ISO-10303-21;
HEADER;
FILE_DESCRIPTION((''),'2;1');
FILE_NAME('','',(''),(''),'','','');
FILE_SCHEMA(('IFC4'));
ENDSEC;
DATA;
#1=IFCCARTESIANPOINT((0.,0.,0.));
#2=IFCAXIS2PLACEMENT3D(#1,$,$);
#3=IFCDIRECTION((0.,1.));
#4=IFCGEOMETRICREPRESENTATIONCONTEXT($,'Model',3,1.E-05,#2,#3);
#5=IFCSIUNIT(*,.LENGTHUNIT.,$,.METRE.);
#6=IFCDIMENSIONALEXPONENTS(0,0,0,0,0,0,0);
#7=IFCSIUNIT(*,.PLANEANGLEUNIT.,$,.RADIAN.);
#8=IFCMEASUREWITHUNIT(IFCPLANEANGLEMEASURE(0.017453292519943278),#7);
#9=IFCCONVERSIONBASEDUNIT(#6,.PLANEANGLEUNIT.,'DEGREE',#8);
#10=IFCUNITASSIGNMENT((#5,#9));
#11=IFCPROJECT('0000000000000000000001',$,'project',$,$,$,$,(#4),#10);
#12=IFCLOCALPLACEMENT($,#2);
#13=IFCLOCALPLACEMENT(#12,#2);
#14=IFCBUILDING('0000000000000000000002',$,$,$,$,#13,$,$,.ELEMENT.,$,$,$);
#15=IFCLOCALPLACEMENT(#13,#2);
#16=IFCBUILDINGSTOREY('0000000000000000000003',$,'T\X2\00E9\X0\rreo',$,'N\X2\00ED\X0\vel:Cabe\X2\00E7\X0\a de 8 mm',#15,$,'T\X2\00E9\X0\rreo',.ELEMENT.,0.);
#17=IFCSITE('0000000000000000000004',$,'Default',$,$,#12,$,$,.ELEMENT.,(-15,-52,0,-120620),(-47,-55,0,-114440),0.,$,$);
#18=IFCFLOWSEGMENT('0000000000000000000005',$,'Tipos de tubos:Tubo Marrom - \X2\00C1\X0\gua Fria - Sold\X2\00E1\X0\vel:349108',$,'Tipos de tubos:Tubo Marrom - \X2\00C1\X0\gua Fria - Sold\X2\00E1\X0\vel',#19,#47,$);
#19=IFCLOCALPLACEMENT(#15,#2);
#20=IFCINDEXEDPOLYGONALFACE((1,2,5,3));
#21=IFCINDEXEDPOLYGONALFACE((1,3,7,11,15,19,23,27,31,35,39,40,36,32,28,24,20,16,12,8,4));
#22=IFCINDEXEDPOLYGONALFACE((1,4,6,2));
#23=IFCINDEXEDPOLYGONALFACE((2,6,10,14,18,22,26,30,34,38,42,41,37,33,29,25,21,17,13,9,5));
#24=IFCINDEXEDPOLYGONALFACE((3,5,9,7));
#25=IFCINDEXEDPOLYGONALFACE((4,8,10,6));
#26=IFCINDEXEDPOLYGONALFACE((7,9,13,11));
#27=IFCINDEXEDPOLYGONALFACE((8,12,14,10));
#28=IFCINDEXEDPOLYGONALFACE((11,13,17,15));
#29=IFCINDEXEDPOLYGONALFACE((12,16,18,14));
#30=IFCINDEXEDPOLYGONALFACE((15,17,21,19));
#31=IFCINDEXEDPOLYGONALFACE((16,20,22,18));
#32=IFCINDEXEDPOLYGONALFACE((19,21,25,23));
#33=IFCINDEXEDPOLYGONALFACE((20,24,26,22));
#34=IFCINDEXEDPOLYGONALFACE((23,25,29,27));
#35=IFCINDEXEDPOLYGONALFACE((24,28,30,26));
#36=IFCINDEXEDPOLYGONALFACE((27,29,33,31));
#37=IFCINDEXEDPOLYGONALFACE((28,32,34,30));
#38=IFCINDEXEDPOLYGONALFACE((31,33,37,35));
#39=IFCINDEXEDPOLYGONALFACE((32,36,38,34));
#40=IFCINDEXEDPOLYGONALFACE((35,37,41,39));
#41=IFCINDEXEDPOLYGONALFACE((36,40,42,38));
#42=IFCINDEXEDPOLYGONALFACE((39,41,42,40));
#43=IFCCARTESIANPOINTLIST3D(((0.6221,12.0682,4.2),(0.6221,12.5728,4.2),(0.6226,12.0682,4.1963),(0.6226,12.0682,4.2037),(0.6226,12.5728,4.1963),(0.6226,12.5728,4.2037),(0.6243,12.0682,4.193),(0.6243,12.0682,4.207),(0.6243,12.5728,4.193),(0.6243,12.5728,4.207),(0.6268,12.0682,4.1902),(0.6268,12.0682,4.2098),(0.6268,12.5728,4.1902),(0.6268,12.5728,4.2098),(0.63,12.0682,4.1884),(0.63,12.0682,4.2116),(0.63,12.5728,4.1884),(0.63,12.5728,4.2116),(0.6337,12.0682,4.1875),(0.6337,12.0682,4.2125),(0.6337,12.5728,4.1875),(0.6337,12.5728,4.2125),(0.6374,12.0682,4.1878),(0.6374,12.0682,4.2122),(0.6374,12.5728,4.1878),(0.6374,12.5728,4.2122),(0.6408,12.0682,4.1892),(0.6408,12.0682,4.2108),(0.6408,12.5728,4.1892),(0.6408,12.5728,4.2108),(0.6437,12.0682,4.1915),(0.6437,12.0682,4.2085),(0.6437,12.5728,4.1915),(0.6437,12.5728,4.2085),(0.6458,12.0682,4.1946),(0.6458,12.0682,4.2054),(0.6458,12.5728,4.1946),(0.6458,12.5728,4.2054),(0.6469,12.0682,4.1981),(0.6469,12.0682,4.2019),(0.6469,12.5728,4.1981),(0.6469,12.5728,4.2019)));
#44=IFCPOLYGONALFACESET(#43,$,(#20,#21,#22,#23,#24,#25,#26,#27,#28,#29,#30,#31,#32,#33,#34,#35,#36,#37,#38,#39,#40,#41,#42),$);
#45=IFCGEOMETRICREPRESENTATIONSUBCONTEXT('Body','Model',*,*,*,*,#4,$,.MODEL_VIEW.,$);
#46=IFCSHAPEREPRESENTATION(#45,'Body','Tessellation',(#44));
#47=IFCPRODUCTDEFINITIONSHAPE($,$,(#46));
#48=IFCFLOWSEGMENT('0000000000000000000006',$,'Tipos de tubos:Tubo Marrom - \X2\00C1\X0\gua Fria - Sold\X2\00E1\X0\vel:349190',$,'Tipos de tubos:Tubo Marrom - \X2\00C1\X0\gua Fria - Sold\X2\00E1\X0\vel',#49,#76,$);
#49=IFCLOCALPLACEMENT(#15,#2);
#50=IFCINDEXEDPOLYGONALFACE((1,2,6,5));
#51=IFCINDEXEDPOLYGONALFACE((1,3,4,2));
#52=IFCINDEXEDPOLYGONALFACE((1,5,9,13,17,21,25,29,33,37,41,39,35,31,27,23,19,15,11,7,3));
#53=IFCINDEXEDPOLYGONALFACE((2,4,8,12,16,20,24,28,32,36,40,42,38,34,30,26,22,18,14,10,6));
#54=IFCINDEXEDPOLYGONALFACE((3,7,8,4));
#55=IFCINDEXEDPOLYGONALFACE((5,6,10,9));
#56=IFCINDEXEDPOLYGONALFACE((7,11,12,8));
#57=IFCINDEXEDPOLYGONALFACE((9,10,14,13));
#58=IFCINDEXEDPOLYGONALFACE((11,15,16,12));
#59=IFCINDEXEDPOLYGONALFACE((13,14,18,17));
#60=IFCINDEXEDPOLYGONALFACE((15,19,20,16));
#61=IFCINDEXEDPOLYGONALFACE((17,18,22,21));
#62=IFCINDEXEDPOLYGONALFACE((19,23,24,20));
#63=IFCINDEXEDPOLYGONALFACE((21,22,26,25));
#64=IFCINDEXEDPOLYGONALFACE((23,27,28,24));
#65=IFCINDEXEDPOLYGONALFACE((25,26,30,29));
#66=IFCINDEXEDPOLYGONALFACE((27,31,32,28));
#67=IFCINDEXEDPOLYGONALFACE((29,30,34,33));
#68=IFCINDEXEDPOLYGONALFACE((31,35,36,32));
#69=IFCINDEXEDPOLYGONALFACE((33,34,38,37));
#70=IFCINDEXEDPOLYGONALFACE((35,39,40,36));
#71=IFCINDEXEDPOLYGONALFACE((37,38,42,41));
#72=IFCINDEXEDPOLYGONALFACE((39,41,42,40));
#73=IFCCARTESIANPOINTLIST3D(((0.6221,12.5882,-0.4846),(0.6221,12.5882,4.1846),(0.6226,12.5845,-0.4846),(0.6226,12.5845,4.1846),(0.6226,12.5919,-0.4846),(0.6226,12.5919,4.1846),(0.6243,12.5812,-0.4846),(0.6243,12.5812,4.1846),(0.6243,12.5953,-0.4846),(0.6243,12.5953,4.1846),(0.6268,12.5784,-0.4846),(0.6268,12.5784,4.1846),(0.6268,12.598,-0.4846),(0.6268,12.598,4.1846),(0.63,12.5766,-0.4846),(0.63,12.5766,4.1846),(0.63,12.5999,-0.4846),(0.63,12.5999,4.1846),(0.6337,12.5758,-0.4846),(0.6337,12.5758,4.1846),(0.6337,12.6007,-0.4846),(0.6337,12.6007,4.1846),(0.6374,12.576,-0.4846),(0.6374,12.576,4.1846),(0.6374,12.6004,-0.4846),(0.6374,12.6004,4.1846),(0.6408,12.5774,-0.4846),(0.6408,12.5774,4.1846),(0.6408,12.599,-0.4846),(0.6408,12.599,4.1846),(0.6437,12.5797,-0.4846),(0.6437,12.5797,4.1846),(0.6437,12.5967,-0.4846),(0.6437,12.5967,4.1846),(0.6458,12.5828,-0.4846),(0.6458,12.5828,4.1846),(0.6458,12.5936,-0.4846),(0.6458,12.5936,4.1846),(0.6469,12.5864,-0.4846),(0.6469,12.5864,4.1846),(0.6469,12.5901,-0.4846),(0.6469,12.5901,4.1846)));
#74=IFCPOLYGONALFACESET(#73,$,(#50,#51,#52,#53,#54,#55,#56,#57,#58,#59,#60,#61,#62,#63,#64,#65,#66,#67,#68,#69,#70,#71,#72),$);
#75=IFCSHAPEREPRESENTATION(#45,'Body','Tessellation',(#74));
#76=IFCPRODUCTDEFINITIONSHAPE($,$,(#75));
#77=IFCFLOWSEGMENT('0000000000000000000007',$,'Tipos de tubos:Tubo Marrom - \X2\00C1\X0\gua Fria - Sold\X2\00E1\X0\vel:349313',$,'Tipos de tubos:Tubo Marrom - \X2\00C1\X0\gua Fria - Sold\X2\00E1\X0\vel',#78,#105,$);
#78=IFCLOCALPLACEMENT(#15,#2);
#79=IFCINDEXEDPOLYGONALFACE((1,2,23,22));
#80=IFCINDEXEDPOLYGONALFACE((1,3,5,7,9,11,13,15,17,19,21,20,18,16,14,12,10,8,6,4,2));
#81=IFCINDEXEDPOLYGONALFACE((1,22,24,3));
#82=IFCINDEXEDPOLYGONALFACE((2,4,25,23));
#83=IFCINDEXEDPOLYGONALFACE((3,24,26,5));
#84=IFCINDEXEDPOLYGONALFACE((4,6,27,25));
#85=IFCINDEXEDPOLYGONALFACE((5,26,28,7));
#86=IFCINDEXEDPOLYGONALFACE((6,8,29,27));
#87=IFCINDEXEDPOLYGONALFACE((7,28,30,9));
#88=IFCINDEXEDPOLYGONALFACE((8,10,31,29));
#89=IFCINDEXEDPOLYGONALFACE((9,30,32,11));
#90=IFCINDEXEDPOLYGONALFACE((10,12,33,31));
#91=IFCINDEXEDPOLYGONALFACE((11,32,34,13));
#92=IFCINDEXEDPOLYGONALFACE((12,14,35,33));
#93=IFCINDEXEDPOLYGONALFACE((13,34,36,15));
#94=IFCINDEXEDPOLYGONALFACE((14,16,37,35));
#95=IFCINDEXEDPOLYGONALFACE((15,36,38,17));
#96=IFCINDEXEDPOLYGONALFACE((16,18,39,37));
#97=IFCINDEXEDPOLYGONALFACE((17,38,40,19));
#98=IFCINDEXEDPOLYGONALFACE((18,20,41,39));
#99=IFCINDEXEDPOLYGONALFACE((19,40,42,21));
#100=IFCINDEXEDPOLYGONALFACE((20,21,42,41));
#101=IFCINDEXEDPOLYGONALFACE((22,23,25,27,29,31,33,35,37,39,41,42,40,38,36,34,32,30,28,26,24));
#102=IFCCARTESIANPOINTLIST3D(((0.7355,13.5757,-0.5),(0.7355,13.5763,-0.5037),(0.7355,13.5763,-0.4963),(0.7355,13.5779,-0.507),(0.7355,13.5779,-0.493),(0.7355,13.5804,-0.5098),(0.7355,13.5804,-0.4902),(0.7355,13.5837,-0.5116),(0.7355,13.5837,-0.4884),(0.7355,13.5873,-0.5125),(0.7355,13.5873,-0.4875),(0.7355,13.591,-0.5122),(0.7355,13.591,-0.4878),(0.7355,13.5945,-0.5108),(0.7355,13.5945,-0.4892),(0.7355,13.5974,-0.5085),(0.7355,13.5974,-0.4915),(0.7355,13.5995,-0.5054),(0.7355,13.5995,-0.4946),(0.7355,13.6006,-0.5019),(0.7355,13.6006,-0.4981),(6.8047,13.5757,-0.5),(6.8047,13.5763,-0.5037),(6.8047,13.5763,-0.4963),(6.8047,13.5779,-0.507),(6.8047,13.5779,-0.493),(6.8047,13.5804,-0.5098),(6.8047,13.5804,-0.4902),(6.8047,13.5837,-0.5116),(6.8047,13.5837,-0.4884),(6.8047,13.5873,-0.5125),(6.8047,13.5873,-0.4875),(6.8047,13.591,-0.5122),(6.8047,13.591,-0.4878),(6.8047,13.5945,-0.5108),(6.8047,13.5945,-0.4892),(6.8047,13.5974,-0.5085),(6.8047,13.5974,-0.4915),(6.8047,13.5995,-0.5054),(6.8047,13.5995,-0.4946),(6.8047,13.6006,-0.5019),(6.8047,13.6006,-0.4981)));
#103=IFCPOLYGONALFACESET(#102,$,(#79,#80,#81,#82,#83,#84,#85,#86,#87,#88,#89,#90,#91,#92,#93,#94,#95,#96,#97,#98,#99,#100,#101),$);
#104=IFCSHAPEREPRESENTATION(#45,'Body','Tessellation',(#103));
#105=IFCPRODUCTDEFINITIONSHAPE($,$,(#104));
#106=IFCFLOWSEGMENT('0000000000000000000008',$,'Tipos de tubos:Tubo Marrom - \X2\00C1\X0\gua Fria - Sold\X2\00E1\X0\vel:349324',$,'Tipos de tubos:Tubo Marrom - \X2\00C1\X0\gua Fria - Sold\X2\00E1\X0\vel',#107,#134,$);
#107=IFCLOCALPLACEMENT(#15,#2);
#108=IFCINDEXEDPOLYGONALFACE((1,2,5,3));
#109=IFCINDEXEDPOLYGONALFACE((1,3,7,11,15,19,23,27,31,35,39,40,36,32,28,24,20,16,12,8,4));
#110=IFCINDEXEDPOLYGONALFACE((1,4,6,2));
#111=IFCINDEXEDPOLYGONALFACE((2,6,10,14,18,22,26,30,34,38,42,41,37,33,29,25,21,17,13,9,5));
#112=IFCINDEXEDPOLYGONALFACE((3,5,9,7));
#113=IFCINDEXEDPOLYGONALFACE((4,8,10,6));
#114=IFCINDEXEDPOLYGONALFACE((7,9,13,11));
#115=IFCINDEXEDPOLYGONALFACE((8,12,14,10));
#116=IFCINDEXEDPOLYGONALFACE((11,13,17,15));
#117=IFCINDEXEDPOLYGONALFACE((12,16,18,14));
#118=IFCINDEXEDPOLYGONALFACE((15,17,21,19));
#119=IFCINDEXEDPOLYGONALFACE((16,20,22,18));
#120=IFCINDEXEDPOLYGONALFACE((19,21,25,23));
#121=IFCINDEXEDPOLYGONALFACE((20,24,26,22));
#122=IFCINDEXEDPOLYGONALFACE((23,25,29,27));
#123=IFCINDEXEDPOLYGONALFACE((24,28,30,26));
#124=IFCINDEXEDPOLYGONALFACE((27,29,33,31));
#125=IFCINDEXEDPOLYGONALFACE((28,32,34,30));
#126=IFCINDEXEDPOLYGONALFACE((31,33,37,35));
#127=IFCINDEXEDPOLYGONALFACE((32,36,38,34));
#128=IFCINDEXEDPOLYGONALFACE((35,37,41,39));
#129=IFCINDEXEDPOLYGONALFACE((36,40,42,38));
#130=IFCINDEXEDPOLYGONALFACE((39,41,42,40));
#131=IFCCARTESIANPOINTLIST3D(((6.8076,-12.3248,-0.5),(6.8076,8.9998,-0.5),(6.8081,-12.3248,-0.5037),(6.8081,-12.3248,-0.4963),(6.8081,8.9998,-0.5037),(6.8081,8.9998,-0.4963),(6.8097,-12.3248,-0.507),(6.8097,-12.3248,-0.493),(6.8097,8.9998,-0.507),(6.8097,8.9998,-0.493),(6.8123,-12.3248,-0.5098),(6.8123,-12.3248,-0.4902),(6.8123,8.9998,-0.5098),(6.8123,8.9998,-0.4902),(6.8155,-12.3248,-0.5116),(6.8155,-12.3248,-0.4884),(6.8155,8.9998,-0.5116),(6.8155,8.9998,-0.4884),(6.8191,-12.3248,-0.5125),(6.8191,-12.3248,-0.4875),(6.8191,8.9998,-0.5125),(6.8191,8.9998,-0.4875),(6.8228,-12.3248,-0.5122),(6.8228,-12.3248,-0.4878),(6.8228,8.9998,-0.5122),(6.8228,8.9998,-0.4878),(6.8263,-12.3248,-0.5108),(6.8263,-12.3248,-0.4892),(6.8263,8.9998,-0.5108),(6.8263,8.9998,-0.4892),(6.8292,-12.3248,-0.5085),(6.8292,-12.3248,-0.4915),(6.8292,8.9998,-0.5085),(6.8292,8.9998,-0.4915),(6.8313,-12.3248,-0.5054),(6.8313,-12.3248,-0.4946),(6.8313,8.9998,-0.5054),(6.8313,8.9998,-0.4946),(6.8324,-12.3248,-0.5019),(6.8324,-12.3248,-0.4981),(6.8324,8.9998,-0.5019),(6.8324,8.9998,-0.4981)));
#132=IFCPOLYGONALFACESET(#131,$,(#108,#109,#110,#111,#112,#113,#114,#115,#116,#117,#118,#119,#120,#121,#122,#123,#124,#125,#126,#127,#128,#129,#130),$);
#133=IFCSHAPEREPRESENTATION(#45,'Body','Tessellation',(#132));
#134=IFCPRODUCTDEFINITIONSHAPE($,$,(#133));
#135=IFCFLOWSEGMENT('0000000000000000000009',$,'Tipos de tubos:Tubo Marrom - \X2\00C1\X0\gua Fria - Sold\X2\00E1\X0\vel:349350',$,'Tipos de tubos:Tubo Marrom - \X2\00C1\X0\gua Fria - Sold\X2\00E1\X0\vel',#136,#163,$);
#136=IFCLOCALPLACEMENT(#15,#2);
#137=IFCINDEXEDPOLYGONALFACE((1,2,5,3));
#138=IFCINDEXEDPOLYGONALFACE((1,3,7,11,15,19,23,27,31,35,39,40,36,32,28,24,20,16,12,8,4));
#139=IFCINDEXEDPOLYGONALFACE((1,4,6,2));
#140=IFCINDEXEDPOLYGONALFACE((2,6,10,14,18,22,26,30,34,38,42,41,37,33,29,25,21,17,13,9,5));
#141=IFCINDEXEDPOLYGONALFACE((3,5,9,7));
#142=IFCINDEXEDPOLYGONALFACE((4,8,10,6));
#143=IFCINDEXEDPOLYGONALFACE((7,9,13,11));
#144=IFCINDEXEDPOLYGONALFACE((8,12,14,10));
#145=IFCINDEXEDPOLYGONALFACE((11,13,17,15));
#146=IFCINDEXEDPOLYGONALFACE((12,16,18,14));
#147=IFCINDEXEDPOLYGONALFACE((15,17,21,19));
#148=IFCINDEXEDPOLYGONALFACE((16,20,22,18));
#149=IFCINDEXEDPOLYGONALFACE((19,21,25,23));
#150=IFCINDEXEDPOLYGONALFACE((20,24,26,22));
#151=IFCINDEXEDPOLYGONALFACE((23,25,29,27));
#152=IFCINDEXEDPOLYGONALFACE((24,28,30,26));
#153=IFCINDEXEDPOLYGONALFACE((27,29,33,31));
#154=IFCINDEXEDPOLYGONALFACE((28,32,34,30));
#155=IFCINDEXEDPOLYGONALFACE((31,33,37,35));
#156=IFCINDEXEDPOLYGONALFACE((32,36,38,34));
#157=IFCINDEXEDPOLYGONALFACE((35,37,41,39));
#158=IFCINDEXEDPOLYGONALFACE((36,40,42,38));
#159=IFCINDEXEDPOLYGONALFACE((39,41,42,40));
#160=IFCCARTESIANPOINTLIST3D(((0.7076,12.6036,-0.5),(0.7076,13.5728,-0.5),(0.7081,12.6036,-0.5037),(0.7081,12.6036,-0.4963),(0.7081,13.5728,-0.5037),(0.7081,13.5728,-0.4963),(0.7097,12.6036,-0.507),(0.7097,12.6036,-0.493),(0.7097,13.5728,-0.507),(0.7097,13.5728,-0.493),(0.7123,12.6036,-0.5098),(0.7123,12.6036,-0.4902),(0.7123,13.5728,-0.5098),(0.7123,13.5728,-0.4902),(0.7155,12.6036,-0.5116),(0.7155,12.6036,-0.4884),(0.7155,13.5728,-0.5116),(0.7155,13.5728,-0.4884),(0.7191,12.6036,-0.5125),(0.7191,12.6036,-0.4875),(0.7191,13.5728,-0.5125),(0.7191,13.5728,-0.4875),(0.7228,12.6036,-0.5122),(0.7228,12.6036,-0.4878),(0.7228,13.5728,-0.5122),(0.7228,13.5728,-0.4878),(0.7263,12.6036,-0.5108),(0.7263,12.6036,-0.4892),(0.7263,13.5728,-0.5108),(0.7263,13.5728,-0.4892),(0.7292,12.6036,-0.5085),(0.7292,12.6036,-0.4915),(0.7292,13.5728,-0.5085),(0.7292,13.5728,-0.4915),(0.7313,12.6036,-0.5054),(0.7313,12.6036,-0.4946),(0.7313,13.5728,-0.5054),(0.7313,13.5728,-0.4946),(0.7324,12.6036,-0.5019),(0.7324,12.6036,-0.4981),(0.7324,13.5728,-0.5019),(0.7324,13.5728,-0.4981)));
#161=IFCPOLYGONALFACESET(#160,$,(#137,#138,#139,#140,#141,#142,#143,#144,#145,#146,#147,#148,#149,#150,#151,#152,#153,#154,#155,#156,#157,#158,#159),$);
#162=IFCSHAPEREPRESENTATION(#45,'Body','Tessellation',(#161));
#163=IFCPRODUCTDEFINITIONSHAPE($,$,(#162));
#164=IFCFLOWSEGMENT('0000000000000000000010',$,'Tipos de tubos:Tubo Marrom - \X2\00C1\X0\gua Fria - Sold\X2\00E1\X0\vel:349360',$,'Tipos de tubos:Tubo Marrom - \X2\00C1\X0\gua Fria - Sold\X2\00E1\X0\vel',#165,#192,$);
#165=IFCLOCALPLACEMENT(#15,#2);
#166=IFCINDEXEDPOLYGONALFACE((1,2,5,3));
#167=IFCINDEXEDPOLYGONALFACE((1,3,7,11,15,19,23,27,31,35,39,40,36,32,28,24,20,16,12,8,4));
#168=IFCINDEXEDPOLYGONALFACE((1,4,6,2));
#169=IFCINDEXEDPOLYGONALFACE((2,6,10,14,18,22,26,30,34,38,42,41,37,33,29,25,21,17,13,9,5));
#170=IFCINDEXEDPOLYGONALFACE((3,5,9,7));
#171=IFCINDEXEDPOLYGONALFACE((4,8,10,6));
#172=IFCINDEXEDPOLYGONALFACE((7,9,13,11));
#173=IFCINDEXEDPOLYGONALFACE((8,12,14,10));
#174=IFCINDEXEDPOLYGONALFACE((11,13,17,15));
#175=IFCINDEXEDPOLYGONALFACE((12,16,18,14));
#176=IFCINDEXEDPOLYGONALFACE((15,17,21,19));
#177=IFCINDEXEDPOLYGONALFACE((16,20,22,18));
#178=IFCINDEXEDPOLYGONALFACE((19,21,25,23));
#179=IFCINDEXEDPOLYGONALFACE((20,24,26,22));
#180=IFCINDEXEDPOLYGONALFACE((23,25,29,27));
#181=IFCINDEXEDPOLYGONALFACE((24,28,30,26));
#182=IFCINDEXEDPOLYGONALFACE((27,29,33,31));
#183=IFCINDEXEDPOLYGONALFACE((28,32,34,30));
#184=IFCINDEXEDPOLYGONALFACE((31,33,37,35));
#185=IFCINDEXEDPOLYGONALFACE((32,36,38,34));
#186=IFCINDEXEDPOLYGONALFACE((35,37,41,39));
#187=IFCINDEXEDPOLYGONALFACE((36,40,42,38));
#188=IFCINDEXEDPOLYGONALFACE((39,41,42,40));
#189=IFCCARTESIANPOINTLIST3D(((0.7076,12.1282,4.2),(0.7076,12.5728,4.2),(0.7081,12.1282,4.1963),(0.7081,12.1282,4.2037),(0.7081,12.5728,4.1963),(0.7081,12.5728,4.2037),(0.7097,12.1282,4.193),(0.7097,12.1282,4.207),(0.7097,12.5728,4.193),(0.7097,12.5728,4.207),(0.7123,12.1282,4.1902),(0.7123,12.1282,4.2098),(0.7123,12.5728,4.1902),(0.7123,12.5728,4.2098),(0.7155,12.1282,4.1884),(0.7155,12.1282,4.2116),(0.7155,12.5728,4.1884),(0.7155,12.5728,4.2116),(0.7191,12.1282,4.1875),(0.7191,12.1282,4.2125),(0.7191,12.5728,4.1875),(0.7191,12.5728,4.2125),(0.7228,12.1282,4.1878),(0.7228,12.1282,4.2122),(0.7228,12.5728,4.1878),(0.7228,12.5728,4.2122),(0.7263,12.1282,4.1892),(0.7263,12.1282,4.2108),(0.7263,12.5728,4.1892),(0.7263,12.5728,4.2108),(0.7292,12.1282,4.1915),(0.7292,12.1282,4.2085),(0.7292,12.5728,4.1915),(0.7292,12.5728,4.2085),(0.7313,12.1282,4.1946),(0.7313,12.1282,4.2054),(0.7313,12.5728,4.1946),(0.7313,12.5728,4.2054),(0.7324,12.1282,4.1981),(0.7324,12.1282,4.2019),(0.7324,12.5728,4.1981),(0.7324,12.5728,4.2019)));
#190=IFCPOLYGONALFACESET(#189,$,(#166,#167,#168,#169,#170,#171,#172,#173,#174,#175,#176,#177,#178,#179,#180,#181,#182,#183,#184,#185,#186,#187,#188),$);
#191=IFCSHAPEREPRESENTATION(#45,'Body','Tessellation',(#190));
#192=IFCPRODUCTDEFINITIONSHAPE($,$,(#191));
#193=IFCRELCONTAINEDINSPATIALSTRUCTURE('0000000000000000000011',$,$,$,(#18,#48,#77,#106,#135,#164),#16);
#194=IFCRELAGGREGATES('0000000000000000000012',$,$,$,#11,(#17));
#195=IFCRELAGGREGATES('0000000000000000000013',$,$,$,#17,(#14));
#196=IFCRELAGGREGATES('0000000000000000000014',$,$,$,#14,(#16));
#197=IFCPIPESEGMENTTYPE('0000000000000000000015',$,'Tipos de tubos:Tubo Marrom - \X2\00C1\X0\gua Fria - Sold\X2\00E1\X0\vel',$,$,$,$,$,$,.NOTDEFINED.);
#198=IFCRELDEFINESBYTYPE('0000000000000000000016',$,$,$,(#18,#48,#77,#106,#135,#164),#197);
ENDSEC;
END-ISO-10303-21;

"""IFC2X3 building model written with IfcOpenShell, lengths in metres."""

from ifc_helpers import new_model, entity, si_unit, converted_unit, direction, frame, frame_2d, origin, origin_2d_with_axis, place, context, subcontext, project, spatial, circle, extrude, type_object, element, save


model = new_model("IFC2X3")

# Units and contexts
model_context = context("Model", 3, precision=1e-05, world=origin(), true_north=direction((0.0, 1.0)))
body_context = subcontext(model_context, "Body", "Model", "MODEL_VIEW")
ifc_project = project(units=[si_unit("LENGTHUNIT", "METRE"), converted_unit("PLANEANGLEUNIT", "DEGREE", entity("IfcPlaneAngleMeasure", 0.017453292519943278), si_unit("PLANEANGLEUNIT", "RADIAN"), dimensions=[0, 0, 0, 0, 0, 0, 0])], contexts=[model_context])

# Site, building, storey
site_placement = place(None, origin())
site = spatial("IfcSite", under=ifc_project, at=site_placement, Name="Default", CompositionType="ELEMENT", RefLatitude=(-15, -52, 0, -120620), RefLongitude=(-47, -55, 0, -114440), RefElevation=0.0)
building_placement = place(site_placement, origin())
building = spatial("IfcBuilding", under=site, at=building_placement, CompositionType="ELEMENT")
storey_placement = place(building_placement, origin())
storey = spatial("IfcBuildingStorey", under=building, at=storey_placement, Name="Térreo", ObjectType="Nível:Cabeça de 8 mm", LongName="Térreo", CompositionType="ELEMENT", Elevation=0.0)

# Flow segments
pipe_segment_type = type_object("IfcPipeSegmentType", Name="Tipos de tubos:Tubo Marrom - Água Fria - Soldável", PredefinedType="NOTDEFINED")
flow_segment_1_placement = place(storey_placement, origin())
element("IfcFlowSegment", 1, at=flow_segment_1_placement, inside=storey, type_object=pipe_segment_type, Name="Tipos de tubos:Tubo Marrom - Água Fria - Soldável:349108", ObjectType="Tipos de tubos:Tubo Marrom - Água Fria - Soldável", context=body_context, shape_type="SweptSolid", body=[
    extrude(circle(Radius=0.0125, at=frame_2d((0.0, 0.0), x_axis=(1.0, 0.0))), frame((0.6346, 12.0682, 4.2), z_axis=(0.0, 1.0, 0.0), x_axis=(-1.0, 0.0, 0.0)), (0.0, 0.0, 1.0), 0.5046),
])
flow_segment_2_placement = place(storey_placement, origin())
element("IfcFlowSegment", 2, at=flow_segment_2_placement, inside=storey, type_object=pipe_segment_type, Name="Tipos de tubos:Tubo Marrom - Água Fria - Soldável:349190", ObjectType="Tipos de tubos:Tubo Marrom - Água Fria - Soldável", context=body_context, shape_type="SweptSolid", body=[
    extrude(circle(Radius=0.0125, at=frame_2d((0.0, 0.0), x_axis=(1.0, 0.0))), frame((0.6346, 12.5882, -0.4846), z_axis=(0.0, 0.0, 1.0), x_axis=(-1.0, 0.0, 0.0)), (0.0, 0.0, 1.0), 4.6692),
])
flow_segment_3_placement = place(storey_placement, origin())
element("IfcFlowSegment", 3, at=flow_segment_3_placement, inside=storey, type_object=pipe_segment_type, Name="Tipos de tubos:Tubo Marrom - Água Fria - Soldável:349313", ObjectType="Tipos de tubos:Tubo Marrom - Água Fria - Soldável", context=body_context, shape_type="SweptSolid", body=[
    extrude(circle(Radius=0.0125, at=origin_2d_with_axis()), frame((0.7355, 13.5882, -0.5), z_axis=(1.0, 0.0, 0.0), x_axis=(0.0, -1.0, 0.0)), (0.0, 0.0, 1.0), 6.0692),
])
flow_segment_4_placement = place(storey_placement, origin())
element("IfcFlowSegment", 4, at=flow_segment_4_placement, inside=storey, type_object=pipe_segment_type, Name="Tipos de tubos:Tubo Marrom - Água Fria - Soldável:349324", ObjectType="Tipos de tubos:Tubo Marrom - Água Fria - Soldável", context=body_context, shape_type="SweptSolid", body=[
    extrude(circle(Radius=0.0125, at=frame_2d((0.0, 0.0), x_axis=(1.0, 0.0))), frame((6.8201, -12.3248, -0.5), z_axis=(0.0, 1.0, 0.0), x_axis=(-1.0, 0.0, 0.0)), (0.0, 0.0, 1.0), 21.3246),
])
flow_segment_5_placement = place(storey_placement, origin())
element("IfcFlowSegment", 5, at=flow_segment_5_placement, inside=storey, type_object=pipe_segment_type, Name="Tipos de tubos:Tubo Marrom - Água Fria - Soldável:349350", ObjectType="Tipos de tubos:Tubo Marrom - Água Fria - Soldável", context=body_context, shape_type="SweptSolid", body=[
    extrude(circle(Radius=0.0125, at=frame_2d((0.0, 0.0), x_axis=(1.0, 0.0))), frame((0.7201, 12.6036, -0.5), z_axis=(0.0, 1.0, 0.0), x_axis=(-1.0, 0.0, 0.0)), (0.0, 0.0, 1.0), 0.9692),
])
flow_segment_6_placement = place(storey_placement, origin())
element("IfcFlowSegment", 6, at=flow_segment_6_placement, inside=storey, type_object=pipe_segment_type, Name="Tipos de tubos:Tubo Marrom - Água Fria - Soldável:349360", ObjectType="Tipos de tubos:Tubo Marrom - Água Fria - Soldável", context=body_context, shape_type="SweptSolid", body=[
    extrude(circle(Radius=0.0125, at=frame_2d((0.0, 0.0), x_axis=(1.0, 0.0))), frame((0.7201, 12.1282, 4.2), z_axis=(0.0, 1.0, 0.0), x_axis=(-1.0, 0.0, 0.0)), (0.0, 0.0, 1.0), 0.4446),
])

save(model, "model.ifc")
